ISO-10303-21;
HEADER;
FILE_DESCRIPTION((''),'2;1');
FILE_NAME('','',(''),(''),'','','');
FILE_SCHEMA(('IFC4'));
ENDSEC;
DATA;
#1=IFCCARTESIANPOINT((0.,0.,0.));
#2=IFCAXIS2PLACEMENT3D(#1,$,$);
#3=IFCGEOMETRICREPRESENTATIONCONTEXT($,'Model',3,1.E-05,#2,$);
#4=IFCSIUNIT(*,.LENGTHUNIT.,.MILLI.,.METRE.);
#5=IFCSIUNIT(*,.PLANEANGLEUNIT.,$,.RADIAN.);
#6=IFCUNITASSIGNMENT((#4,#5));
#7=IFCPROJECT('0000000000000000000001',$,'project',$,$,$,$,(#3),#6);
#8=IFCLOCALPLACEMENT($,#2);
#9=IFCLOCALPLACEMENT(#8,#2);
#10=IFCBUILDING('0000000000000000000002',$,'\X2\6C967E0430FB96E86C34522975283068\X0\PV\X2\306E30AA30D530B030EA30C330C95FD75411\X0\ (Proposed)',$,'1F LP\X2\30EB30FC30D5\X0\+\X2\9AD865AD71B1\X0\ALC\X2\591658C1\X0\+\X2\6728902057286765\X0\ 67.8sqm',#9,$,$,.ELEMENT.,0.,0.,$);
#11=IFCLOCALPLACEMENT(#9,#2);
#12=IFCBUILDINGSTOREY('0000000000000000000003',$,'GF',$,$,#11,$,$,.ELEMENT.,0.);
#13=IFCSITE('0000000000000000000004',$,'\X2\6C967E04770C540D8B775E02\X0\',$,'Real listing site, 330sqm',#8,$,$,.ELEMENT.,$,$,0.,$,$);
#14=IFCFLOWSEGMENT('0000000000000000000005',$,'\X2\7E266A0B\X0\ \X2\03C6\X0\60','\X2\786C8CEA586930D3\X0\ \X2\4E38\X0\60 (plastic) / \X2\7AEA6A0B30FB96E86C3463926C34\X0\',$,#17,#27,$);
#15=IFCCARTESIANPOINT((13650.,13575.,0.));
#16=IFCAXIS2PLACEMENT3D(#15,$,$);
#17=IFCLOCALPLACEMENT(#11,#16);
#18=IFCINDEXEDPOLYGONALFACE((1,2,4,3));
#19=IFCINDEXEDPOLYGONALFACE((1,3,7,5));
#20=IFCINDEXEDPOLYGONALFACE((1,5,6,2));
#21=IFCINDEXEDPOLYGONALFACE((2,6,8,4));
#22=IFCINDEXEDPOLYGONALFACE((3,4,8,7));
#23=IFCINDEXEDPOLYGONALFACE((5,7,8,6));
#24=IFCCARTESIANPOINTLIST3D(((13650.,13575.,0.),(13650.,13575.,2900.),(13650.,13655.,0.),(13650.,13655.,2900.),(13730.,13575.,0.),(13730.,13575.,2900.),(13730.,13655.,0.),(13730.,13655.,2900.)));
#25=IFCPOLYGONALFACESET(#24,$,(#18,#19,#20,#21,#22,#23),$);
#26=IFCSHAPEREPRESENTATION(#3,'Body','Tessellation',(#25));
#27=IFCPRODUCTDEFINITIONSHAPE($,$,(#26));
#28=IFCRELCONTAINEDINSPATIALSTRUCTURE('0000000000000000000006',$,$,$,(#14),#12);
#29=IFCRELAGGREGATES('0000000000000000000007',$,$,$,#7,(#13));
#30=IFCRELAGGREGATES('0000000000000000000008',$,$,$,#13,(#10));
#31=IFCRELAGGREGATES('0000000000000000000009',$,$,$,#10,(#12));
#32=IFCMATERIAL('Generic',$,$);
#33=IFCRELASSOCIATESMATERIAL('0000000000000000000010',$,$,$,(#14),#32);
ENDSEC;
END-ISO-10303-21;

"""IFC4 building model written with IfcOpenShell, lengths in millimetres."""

from ifc_helpers import new_model, si_unit, frame, frame_2d, origin, place, context, project, spatial, rectangle, extrude, material, element, save


model = new_model("IFC4")

# Units and contexts
model_context = context("Model", 3, precision=1e-05, world=origin())
ifc_project = project(units=[si_unit("LENGTHUNIT", "METRE", prefix="MILLI"), si_unit("PLANEANGLEUNIT", "RADIAN")], contexts=[model_context])

# Site, building, storey
site_placement = place(None, origin())
site = spatial("IfcSite", under=ifc_project, at=site_placement, Name="沖縄県名護市", ObjectType="Real listing site, 330sqm", CompositionType="ELEMENT", RefElevation=0.0)
building_placement = place(site_placement, origin())
building = spatial("IfcBuilding", under=site, at=building_placement, Name="沖縄・雨水利用とPVのオフグリッド志向 (Proposed)", ObjectType="1F LPルーフ+高断熱ALC外壁+木造在来 67.8sqm", CompositionType="ELEMENT", ElevationOfRefHeight=0.0, ElevationOfTerrain=0.0)
storey_placement = place(building_placement, origin())
storey = spatial("IfcBuildingStorey", under=building, at=storey_placement, Name="GF", CompositionType="ELEMENT", Elevation=0.0)

# Shared definitions
ifc_material_1 = material(Name="Generic")

# Flow segment
flow_segment_placement = place(storey_placement, frame((13650.0, 13575.0, 0.0)))
element("IfcFlowSegment", 1, at=flow_segment_placement, inside=storey, material=ifc_material_1, Name="縦樋 φ60", Description="硬質塩ビ 丸60 (plastic) / 竪樋・雨水排水", context=model_context, shape_type="SweptSolid", body=[
    extrude(rectangle(XDim=80.0, YDim=80.0, at=frame_2d((40.0, 40.0))), frame((13650.0, 13575.0, 0.0)), (0.0, 0.0, 1.0), 2900.0),
])

save(model, "model.ifc")
